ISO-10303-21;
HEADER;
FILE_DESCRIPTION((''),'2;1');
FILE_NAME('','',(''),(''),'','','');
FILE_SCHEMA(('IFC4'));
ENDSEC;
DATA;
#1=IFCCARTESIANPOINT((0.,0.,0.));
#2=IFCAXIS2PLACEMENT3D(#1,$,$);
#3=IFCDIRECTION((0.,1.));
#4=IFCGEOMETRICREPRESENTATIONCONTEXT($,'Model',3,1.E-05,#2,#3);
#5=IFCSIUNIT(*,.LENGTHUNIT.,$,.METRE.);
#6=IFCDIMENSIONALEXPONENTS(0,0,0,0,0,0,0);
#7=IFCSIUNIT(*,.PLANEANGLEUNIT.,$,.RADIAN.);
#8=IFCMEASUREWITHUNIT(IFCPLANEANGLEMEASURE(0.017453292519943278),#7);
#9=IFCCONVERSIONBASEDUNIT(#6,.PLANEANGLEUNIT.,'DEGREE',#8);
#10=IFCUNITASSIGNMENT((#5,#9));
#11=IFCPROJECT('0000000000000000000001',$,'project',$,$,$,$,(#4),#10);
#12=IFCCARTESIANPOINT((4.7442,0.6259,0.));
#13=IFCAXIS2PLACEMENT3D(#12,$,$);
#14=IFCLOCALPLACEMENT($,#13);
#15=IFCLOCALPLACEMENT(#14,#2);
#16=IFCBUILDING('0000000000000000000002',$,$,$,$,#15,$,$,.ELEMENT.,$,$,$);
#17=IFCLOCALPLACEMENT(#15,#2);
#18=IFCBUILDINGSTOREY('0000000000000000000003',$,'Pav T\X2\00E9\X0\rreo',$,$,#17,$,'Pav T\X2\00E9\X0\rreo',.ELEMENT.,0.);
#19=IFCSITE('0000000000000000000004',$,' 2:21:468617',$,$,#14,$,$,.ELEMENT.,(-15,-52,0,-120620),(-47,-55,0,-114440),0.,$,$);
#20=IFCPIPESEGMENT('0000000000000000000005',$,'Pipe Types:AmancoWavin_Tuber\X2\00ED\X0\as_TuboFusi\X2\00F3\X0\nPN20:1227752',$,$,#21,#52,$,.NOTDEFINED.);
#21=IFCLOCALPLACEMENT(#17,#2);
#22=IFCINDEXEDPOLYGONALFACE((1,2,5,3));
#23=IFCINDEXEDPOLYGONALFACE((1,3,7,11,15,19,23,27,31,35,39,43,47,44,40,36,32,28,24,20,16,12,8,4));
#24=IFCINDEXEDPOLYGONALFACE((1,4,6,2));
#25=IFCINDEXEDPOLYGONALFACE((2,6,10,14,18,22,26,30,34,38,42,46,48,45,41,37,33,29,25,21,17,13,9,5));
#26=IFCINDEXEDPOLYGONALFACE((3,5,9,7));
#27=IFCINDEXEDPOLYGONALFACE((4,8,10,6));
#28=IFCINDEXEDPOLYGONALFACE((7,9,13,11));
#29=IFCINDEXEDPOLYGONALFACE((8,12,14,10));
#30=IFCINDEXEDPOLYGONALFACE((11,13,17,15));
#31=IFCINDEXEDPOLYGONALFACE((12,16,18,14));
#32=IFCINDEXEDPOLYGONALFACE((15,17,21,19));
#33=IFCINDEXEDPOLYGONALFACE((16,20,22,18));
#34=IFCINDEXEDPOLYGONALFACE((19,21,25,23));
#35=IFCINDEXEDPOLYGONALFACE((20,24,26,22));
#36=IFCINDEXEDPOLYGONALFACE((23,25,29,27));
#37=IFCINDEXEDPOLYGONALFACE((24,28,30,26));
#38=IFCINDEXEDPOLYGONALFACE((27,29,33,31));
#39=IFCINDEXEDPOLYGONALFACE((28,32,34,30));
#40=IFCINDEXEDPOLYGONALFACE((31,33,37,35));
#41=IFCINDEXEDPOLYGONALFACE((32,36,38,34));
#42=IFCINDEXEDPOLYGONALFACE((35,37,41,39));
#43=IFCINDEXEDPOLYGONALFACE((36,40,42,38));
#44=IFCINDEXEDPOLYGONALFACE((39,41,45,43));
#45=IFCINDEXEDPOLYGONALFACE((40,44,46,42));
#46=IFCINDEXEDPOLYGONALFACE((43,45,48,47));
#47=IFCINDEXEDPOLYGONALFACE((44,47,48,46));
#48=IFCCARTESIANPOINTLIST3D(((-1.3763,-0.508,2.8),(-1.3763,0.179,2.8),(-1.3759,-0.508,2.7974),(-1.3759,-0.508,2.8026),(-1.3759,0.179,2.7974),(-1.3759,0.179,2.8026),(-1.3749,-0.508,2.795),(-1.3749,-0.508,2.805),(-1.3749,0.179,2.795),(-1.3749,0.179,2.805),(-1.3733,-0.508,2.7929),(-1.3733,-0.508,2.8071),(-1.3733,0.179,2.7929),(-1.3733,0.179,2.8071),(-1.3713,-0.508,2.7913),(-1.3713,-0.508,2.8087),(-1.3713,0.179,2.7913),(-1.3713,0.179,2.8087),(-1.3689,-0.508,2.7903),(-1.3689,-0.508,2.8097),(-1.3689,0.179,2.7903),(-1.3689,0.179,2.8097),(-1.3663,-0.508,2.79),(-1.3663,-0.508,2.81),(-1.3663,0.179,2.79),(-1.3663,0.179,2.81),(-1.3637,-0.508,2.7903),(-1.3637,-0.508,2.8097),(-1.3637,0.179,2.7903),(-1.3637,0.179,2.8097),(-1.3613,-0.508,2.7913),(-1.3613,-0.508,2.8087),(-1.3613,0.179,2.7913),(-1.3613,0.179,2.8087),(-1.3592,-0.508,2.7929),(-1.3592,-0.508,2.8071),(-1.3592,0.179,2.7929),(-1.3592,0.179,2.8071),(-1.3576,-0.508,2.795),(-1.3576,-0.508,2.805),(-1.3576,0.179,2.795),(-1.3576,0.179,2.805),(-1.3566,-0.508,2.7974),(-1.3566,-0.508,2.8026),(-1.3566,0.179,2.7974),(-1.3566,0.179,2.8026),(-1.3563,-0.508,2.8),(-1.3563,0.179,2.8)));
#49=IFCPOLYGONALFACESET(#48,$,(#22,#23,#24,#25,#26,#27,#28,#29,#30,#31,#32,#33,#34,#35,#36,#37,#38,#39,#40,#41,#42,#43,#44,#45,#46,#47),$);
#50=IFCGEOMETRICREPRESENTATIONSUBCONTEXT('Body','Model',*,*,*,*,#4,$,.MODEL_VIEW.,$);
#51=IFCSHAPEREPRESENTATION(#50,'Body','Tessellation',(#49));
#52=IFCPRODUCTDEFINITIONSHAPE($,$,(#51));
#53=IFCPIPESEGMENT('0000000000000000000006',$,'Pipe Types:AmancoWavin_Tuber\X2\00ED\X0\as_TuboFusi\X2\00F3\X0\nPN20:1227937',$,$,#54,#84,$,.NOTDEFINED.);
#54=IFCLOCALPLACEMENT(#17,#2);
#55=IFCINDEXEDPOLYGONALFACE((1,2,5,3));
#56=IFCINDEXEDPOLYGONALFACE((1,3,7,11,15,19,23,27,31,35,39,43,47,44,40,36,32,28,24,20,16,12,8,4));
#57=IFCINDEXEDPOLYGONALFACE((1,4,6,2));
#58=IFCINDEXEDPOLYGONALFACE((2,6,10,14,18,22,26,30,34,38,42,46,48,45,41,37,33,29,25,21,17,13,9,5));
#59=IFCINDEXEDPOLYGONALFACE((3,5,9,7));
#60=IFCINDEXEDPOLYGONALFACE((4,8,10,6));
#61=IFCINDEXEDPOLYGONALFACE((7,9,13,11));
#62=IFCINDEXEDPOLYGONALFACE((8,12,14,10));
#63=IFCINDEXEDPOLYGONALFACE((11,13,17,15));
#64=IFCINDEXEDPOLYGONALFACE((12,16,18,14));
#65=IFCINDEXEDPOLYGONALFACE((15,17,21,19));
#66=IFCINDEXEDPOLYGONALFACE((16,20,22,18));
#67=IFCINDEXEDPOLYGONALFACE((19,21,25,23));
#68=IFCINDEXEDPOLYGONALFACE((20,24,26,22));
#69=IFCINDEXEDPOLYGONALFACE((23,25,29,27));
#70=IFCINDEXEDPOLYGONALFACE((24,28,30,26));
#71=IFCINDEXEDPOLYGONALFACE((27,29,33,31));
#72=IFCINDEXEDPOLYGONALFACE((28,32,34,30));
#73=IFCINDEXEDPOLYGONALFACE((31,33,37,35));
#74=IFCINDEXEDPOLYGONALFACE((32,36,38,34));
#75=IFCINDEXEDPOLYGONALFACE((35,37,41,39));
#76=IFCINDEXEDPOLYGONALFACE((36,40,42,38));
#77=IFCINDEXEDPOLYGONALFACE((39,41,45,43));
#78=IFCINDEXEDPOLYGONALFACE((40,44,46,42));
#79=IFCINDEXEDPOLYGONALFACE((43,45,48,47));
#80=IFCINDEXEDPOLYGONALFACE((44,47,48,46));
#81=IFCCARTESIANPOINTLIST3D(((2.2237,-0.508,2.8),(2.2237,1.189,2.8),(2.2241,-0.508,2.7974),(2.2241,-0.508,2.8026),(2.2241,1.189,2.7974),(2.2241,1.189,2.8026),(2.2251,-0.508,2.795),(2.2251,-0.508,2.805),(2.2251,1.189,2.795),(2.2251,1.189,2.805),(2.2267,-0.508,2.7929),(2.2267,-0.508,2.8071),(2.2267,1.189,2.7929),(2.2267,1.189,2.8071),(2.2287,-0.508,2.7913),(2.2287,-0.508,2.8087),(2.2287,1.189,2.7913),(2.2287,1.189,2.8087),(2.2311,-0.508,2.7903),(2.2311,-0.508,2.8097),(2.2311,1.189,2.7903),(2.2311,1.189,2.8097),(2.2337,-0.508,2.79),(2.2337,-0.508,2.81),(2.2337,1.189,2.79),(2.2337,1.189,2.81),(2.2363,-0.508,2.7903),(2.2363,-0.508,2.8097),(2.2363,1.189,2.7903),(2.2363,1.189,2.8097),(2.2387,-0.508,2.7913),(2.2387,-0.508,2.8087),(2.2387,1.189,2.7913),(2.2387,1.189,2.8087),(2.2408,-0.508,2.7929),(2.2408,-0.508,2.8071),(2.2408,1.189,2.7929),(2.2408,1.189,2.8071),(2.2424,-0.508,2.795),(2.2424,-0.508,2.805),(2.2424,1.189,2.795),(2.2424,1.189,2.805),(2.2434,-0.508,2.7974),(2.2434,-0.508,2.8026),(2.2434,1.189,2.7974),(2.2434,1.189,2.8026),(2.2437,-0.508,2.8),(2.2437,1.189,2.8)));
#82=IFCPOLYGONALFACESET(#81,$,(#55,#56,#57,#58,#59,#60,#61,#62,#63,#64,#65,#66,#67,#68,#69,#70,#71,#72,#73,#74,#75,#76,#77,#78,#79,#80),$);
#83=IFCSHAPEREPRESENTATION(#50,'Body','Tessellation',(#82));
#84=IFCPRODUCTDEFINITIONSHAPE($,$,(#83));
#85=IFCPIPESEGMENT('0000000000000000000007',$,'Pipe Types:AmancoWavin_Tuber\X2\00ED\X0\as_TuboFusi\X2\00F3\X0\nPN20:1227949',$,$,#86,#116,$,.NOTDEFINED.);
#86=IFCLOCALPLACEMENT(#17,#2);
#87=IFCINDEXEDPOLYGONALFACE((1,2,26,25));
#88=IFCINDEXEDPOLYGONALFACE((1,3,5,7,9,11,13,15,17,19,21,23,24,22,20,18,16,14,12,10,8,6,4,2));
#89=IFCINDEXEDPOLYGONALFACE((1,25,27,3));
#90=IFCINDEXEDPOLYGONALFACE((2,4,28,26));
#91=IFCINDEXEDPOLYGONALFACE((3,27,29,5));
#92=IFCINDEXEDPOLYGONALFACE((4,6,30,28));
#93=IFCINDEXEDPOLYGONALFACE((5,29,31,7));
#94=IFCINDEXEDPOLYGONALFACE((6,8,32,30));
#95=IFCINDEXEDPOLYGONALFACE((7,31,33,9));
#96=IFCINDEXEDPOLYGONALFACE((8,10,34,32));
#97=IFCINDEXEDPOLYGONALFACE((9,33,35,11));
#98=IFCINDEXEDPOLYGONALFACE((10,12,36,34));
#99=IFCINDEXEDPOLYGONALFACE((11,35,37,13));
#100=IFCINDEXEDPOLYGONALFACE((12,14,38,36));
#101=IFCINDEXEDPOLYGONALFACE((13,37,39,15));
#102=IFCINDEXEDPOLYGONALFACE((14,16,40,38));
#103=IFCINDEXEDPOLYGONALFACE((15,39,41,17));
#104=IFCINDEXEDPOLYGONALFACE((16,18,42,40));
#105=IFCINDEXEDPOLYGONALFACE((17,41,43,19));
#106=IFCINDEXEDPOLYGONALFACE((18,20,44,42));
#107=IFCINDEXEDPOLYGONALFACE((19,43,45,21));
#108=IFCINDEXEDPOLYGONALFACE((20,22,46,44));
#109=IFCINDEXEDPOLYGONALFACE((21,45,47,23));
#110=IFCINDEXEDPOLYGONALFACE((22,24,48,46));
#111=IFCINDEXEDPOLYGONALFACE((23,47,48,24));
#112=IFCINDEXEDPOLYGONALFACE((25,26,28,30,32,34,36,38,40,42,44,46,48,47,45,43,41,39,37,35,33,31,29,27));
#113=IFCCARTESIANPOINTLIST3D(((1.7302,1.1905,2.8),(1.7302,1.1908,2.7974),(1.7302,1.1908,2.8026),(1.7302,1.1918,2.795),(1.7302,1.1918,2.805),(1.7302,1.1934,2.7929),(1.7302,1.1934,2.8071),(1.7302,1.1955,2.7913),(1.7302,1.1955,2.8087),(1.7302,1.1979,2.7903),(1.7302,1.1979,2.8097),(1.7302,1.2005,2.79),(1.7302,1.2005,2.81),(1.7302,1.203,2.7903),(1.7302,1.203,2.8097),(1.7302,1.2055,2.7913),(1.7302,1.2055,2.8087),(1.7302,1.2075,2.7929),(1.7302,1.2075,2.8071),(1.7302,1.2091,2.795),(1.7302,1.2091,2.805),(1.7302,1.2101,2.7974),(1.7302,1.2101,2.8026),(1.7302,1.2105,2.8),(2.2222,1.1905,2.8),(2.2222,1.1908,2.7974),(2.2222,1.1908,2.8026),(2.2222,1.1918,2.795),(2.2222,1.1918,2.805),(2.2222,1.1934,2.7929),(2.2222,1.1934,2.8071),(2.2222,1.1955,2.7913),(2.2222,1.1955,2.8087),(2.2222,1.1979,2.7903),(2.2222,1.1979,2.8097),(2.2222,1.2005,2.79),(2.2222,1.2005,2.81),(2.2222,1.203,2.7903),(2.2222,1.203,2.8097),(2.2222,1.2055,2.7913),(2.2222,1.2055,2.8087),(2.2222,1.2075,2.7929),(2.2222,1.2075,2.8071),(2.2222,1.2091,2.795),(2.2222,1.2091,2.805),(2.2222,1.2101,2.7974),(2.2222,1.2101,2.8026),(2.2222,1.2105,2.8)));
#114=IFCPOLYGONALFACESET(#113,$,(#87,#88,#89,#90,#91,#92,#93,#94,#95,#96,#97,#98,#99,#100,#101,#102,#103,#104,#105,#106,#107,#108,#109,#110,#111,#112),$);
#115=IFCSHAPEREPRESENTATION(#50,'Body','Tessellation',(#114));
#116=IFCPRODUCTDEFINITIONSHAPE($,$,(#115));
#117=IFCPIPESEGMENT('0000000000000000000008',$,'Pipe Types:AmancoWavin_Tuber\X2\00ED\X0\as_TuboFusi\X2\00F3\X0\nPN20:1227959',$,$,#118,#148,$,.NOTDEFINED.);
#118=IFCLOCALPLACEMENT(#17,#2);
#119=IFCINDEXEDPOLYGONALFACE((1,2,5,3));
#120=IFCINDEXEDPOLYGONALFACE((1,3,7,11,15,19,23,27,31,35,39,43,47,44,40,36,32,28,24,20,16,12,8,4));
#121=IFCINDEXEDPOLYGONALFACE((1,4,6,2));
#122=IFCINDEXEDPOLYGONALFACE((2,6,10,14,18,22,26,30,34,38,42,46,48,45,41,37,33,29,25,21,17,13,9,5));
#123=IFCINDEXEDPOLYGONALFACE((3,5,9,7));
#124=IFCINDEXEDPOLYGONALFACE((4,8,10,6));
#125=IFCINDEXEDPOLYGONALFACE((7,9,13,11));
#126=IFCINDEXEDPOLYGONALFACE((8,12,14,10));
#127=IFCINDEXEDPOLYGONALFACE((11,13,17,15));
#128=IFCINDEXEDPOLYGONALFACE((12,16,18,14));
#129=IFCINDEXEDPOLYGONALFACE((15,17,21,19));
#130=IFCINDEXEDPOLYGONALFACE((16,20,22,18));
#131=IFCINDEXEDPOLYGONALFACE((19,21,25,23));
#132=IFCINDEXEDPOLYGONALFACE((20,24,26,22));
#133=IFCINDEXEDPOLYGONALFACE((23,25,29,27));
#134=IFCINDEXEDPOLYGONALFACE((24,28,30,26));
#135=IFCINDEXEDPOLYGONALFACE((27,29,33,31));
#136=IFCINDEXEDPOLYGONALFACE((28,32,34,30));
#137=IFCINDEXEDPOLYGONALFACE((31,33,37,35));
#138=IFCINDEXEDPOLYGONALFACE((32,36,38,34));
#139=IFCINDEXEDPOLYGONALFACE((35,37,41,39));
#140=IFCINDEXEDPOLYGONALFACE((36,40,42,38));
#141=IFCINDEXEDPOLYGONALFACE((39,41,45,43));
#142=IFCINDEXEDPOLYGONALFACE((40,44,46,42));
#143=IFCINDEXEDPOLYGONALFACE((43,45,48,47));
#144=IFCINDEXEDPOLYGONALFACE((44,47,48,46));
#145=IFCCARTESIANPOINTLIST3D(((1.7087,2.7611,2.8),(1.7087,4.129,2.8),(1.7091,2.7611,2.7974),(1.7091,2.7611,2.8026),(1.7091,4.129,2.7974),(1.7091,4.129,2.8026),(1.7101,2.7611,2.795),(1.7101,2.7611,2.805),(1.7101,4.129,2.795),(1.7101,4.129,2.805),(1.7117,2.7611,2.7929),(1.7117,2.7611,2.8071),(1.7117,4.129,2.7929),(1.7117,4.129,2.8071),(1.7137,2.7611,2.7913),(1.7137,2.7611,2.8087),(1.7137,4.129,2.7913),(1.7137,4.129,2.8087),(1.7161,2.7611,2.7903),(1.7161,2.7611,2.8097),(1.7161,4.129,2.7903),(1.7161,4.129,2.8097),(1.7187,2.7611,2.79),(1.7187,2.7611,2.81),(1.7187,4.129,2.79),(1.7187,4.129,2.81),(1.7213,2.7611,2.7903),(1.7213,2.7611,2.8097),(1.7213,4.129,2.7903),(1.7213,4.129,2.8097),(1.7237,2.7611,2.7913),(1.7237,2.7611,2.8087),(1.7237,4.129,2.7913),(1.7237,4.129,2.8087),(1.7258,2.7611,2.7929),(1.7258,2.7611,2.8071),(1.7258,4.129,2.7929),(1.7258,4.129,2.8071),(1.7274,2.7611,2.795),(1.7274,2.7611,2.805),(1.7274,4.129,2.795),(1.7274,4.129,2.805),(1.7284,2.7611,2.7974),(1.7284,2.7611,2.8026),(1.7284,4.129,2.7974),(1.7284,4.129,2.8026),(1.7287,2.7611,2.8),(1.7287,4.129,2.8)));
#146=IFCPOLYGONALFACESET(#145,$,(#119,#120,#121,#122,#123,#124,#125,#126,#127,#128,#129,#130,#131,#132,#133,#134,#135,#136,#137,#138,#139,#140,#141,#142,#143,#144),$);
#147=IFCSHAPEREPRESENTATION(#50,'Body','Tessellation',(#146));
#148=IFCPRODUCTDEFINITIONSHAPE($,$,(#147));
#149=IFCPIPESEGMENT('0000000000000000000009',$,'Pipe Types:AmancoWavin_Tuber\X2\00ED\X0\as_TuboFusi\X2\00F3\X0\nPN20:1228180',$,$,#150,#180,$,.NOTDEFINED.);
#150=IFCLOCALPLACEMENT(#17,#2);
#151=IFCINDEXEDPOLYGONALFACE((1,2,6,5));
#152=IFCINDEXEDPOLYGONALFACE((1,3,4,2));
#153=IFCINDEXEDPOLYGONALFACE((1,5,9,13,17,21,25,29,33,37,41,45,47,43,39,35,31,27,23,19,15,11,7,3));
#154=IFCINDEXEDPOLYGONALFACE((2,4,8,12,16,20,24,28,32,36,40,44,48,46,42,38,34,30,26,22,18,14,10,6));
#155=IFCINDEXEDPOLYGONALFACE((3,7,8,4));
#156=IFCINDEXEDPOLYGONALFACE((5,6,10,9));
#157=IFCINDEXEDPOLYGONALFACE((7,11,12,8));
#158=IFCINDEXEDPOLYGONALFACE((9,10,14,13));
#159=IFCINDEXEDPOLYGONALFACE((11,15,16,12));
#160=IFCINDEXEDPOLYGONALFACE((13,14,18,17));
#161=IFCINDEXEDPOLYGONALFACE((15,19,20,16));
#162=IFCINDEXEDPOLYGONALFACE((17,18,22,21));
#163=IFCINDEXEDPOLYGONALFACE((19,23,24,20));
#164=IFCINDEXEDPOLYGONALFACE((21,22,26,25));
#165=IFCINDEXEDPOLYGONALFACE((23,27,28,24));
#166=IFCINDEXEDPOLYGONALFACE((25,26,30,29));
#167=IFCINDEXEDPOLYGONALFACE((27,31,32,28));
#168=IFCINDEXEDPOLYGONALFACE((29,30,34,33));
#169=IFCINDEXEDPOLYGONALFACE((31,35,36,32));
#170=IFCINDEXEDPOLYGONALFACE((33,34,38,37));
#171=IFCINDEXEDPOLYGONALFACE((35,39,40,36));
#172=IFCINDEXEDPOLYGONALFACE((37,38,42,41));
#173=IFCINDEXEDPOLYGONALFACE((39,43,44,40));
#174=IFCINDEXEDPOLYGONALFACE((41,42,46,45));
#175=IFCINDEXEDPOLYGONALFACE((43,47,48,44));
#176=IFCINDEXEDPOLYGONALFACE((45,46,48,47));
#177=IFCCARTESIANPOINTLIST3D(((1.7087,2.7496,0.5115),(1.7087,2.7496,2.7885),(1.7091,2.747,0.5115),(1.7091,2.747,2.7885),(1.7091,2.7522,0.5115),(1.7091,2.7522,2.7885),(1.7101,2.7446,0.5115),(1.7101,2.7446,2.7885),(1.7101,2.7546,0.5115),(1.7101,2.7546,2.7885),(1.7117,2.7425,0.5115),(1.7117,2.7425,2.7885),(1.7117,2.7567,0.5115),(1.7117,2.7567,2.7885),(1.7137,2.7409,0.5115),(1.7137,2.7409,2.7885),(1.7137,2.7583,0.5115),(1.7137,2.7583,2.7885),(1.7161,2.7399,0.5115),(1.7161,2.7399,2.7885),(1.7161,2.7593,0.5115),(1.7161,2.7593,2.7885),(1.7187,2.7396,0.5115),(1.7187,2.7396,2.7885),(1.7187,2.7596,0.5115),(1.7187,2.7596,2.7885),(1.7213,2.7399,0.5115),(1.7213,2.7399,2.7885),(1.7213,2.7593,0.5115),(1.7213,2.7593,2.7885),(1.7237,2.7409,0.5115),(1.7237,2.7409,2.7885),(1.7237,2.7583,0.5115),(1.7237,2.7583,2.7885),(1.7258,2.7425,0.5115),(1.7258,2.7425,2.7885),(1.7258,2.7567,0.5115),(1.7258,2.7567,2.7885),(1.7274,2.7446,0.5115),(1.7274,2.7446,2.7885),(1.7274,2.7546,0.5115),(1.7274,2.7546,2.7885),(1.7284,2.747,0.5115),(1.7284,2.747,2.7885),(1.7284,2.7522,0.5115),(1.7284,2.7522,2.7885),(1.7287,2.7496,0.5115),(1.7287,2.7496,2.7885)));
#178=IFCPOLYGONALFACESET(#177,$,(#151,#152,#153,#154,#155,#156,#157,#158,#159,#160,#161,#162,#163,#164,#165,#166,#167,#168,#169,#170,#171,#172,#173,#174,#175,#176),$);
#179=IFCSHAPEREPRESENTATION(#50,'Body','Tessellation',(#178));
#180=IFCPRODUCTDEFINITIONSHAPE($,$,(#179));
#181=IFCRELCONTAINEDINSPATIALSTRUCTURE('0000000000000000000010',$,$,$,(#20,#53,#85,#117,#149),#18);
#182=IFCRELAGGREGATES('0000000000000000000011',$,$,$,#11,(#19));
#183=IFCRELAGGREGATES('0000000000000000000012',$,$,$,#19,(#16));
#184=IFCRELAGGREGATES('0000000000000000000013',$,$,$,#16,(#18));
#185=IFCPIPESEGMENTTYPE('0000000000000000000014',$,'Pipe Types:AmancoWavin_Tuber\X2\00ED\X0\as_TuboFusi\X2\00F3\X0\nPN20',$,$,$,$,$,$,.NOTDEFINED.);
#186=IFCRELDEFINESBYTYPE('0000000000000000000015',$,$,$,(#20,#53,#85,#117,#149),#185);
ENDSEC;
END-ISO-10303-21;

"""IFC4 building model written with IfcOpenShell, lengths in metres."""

from ifc_helpers import new_model, entity, si_unit, converted_unit, direction, frame, origin, place, context, subcontext, project, spatial, arc, indexed_curve, outline, extrude, type_object, element, save


model = new_model("IFC4")

# Units and contexts
model_context = context("Model", 3, precision=1e-05, world=origin(), true_north=direction((0.0, 1.0)))
body_context = subcontext(model_context, "Body", "Model", "MODEL_VIEW")
ifc_project = project(units=[si_unit("LENGTHUNIT", "METRE"), converted_unit("PLANEANGLEUNIT", "DEGREE", entity("IfcPlaneAngleMeasure", 0.017453292519943278), si_unit("PLANEANGLEUNIT", "RADIAN"), dimensions=[0, 0, 0, 0, 0, 0, 0])], contexts=[model_context])

# Site, building, storey
site_placement = place(None, frame((4.7442, 0.6259, 0.0)))
site = spatial("IfcSite", under=ifc_project, at=site_placement, Name=" 2:21:468617", CompositionType="ELEMENT", RefLatitude=(-15, -52, 0, -120620), RefLongitude=(-47, -55, 0, -114440), RefElevation=0.0)
building_placement = place(site_placement, origin())
building = spatial("IfcBuilding", under=site, at=building_placement, CompositionType="ELEMENT")
storey_placement = place(building_placement, origin())
storey = spatial("IfcBuildingStorey", under=building, at=storey_placement, Name="Pav Térreo", LongName="Pav Térreo", CompositionType="ELEMENT", Elevation=0.0)

# Pipe segments
pipe_segment_type_1 = type_object("IfcPipeSegmentType", Name="Pipe Types:AmancoWavin_Tuberías_TuboFusiónPN20", PredefinedType="NOTDEFINED")
pipe_segment_1_placement = place(storey_placement, origin())
element("IfcPipeSegment", 1, at=pipe_segment_1_placement, inside=storey, type_object=pipe_segment_type_1, Name="Pipe Types:AmancoWavin_Tuberías_TuboFusiónPN20:1227752", PredefinedType="NOTDEFINED", context=body_context, shape_type="SweptSolid", body=[
    extrude(outline(indexed_curve([(0.01, 0.0), (0.0071, 0.0071), (0.0, 0.01), (-0.0071, 0.0071), (-0.01, 0.0), (-0.0071, -0.0071), (0.0, -0.01), (0.0071, -0.0071)], segments=[arc(1, 2, 3), arc(3, 4, 5), arc(5, 6, 7), arc(7, 8, 1)], self_intersect=False)), frame((-1.3663, -0.508, 2.8), z_axis=(0.0, 1.0, 0.0), x_axis=(-1.0, 0.0, 0.0)), (0.0, 0.0, 1.0), 0.687),
])
pipe_segment_2_placement = place(storey_placement, origin())
element("IfcPipeSegment", 2, at=pipe_segment_2_placement, inside=storey, type_object=pipe_segment_type_1, Name="Pipe Types:AmancoWavin_Tuberías_TuboFusiónPN20:1227937", PredefinedType="NOTDEFINED", context=body_context, shape_type="SweptSolid", body=[
    extrude(outline(indexed_curve([(0.01, 0.0), (0.0071, 0.0071), (0.0, 0.01), (-0.0071, 0.0071), (-0.01, 0.0), (-0.0071, -0.0071), (0.0, -0.01), (0.0071, -0.0071)], segments=[arc(1, 2, 3), arc(3, 4, 5), arc(5, 6, 7), arc(7, 8, 1)], self_intersect=False)), frame((2.2337, -0.508, 2.8), z_axis=(0.0, 1.0, 0.0), x_axis=(1.0, 0.0, 0.0)), (0.0, 0.0, 1.0), 1.697),
])
pipe_segment_3_placement = place(storey_placement, origin())
element("IfcPipeSegment", 3, at=pipe_segment_3_placement, inside=storey, type_object=pipe_segment_type_1, Name="Pipe Types:AmancoWavin_Tuberías_TuboFusiónPN20:1227949", PredefinedType="NOTDEFINED", context=body_context, shape_type="SweptSolid", body=[
    extrude(outline(indexed_curve([(0.01, 0.0), (0.0071, 0.0071), (0.0, 0.01), (-0.0071, 0.0071), (-0.01, 0.0), (-0.0071, -0.0071), (0.0, -0.01), (0.0071, -0.0071)], segments=[arc(1, 2, 3), arc(3, 4, 5), arc(5, 6, 7), arc(7, 8, 1)], self_intersect=False)), frame((1.7302, 1.2005, 2.8), z_axis=(1.0, 0.0, 0.0), x_axis=(0.0, 1.0, 0.0)), (0.0, 0.0, 1.0), 0.492),
])
pipe_segment_4_placement = place(storey_placement, origin())
element("IfcPipeSegment", 4, at=pipe_segment_4_placement, inside=storey, type_object=pipe_segment_type_1, Name="Pipe Types:AmancoWavin_Tuberías_TuboFusiónPN20:1227959", PredefinedType="NOTDEFINED", context=body_context, shape_type="SweptSolid", body=[
    extrude(outline(indexed_curve([(0.01, 0.0), (0.0071, 0.0071), (0.0, 0.01), (-0.0071, 0.0071), (-0.01, 0.0), (-0.0071, -0.0071), (0.0, -0.01), (0.0071, -0.0071)], segments=[arc(1, 2, 3), arc(3, 4, 5), arc(5, 6, 7), arc(7, 8, 1)], self_intersect=False)), frame((1.7187, 2.7611, 2.8), z_axis=(0.0, 1.0, 0.0), x_axis=(1.0, 0.0, 0.0)), (0.0, 0.0, 1.0), 1.3679),
])
pipe_segment_5_placement = place(storey_placement, origin())
element("IfcPipeSegment", 5, at=pipe_segment_5_placement, inside=storey, type_object=pipe_segment_type_1, Name="Pipe Types:AmancoWavin_Tuberías_TuboFusiónPN20:1228180", PredefinedType="NOTDEFINED", context=body_context, shape_type="SweptSolid", body=[
    extrude(outline(indexed_curve([(0.01, 0.0), (0.0071, 0.0071), (0.0, 0.01), (-0.0071, 0.0071), (-0.01, 0.0), (-0.0071, -0.0071), (0.0, -0.01), (0.0071, -0.0071)], segments=[arc(1, 2, 3), arc(3, 4, 5), arc(5, 6, 7), arc(7, 8, 1)], self_intersect=False)), frame((1.7187, 2.7496, 0.5115)), (0.0, 0.0, 1.0), 2.277),
])

save(model, "model.ifc")
